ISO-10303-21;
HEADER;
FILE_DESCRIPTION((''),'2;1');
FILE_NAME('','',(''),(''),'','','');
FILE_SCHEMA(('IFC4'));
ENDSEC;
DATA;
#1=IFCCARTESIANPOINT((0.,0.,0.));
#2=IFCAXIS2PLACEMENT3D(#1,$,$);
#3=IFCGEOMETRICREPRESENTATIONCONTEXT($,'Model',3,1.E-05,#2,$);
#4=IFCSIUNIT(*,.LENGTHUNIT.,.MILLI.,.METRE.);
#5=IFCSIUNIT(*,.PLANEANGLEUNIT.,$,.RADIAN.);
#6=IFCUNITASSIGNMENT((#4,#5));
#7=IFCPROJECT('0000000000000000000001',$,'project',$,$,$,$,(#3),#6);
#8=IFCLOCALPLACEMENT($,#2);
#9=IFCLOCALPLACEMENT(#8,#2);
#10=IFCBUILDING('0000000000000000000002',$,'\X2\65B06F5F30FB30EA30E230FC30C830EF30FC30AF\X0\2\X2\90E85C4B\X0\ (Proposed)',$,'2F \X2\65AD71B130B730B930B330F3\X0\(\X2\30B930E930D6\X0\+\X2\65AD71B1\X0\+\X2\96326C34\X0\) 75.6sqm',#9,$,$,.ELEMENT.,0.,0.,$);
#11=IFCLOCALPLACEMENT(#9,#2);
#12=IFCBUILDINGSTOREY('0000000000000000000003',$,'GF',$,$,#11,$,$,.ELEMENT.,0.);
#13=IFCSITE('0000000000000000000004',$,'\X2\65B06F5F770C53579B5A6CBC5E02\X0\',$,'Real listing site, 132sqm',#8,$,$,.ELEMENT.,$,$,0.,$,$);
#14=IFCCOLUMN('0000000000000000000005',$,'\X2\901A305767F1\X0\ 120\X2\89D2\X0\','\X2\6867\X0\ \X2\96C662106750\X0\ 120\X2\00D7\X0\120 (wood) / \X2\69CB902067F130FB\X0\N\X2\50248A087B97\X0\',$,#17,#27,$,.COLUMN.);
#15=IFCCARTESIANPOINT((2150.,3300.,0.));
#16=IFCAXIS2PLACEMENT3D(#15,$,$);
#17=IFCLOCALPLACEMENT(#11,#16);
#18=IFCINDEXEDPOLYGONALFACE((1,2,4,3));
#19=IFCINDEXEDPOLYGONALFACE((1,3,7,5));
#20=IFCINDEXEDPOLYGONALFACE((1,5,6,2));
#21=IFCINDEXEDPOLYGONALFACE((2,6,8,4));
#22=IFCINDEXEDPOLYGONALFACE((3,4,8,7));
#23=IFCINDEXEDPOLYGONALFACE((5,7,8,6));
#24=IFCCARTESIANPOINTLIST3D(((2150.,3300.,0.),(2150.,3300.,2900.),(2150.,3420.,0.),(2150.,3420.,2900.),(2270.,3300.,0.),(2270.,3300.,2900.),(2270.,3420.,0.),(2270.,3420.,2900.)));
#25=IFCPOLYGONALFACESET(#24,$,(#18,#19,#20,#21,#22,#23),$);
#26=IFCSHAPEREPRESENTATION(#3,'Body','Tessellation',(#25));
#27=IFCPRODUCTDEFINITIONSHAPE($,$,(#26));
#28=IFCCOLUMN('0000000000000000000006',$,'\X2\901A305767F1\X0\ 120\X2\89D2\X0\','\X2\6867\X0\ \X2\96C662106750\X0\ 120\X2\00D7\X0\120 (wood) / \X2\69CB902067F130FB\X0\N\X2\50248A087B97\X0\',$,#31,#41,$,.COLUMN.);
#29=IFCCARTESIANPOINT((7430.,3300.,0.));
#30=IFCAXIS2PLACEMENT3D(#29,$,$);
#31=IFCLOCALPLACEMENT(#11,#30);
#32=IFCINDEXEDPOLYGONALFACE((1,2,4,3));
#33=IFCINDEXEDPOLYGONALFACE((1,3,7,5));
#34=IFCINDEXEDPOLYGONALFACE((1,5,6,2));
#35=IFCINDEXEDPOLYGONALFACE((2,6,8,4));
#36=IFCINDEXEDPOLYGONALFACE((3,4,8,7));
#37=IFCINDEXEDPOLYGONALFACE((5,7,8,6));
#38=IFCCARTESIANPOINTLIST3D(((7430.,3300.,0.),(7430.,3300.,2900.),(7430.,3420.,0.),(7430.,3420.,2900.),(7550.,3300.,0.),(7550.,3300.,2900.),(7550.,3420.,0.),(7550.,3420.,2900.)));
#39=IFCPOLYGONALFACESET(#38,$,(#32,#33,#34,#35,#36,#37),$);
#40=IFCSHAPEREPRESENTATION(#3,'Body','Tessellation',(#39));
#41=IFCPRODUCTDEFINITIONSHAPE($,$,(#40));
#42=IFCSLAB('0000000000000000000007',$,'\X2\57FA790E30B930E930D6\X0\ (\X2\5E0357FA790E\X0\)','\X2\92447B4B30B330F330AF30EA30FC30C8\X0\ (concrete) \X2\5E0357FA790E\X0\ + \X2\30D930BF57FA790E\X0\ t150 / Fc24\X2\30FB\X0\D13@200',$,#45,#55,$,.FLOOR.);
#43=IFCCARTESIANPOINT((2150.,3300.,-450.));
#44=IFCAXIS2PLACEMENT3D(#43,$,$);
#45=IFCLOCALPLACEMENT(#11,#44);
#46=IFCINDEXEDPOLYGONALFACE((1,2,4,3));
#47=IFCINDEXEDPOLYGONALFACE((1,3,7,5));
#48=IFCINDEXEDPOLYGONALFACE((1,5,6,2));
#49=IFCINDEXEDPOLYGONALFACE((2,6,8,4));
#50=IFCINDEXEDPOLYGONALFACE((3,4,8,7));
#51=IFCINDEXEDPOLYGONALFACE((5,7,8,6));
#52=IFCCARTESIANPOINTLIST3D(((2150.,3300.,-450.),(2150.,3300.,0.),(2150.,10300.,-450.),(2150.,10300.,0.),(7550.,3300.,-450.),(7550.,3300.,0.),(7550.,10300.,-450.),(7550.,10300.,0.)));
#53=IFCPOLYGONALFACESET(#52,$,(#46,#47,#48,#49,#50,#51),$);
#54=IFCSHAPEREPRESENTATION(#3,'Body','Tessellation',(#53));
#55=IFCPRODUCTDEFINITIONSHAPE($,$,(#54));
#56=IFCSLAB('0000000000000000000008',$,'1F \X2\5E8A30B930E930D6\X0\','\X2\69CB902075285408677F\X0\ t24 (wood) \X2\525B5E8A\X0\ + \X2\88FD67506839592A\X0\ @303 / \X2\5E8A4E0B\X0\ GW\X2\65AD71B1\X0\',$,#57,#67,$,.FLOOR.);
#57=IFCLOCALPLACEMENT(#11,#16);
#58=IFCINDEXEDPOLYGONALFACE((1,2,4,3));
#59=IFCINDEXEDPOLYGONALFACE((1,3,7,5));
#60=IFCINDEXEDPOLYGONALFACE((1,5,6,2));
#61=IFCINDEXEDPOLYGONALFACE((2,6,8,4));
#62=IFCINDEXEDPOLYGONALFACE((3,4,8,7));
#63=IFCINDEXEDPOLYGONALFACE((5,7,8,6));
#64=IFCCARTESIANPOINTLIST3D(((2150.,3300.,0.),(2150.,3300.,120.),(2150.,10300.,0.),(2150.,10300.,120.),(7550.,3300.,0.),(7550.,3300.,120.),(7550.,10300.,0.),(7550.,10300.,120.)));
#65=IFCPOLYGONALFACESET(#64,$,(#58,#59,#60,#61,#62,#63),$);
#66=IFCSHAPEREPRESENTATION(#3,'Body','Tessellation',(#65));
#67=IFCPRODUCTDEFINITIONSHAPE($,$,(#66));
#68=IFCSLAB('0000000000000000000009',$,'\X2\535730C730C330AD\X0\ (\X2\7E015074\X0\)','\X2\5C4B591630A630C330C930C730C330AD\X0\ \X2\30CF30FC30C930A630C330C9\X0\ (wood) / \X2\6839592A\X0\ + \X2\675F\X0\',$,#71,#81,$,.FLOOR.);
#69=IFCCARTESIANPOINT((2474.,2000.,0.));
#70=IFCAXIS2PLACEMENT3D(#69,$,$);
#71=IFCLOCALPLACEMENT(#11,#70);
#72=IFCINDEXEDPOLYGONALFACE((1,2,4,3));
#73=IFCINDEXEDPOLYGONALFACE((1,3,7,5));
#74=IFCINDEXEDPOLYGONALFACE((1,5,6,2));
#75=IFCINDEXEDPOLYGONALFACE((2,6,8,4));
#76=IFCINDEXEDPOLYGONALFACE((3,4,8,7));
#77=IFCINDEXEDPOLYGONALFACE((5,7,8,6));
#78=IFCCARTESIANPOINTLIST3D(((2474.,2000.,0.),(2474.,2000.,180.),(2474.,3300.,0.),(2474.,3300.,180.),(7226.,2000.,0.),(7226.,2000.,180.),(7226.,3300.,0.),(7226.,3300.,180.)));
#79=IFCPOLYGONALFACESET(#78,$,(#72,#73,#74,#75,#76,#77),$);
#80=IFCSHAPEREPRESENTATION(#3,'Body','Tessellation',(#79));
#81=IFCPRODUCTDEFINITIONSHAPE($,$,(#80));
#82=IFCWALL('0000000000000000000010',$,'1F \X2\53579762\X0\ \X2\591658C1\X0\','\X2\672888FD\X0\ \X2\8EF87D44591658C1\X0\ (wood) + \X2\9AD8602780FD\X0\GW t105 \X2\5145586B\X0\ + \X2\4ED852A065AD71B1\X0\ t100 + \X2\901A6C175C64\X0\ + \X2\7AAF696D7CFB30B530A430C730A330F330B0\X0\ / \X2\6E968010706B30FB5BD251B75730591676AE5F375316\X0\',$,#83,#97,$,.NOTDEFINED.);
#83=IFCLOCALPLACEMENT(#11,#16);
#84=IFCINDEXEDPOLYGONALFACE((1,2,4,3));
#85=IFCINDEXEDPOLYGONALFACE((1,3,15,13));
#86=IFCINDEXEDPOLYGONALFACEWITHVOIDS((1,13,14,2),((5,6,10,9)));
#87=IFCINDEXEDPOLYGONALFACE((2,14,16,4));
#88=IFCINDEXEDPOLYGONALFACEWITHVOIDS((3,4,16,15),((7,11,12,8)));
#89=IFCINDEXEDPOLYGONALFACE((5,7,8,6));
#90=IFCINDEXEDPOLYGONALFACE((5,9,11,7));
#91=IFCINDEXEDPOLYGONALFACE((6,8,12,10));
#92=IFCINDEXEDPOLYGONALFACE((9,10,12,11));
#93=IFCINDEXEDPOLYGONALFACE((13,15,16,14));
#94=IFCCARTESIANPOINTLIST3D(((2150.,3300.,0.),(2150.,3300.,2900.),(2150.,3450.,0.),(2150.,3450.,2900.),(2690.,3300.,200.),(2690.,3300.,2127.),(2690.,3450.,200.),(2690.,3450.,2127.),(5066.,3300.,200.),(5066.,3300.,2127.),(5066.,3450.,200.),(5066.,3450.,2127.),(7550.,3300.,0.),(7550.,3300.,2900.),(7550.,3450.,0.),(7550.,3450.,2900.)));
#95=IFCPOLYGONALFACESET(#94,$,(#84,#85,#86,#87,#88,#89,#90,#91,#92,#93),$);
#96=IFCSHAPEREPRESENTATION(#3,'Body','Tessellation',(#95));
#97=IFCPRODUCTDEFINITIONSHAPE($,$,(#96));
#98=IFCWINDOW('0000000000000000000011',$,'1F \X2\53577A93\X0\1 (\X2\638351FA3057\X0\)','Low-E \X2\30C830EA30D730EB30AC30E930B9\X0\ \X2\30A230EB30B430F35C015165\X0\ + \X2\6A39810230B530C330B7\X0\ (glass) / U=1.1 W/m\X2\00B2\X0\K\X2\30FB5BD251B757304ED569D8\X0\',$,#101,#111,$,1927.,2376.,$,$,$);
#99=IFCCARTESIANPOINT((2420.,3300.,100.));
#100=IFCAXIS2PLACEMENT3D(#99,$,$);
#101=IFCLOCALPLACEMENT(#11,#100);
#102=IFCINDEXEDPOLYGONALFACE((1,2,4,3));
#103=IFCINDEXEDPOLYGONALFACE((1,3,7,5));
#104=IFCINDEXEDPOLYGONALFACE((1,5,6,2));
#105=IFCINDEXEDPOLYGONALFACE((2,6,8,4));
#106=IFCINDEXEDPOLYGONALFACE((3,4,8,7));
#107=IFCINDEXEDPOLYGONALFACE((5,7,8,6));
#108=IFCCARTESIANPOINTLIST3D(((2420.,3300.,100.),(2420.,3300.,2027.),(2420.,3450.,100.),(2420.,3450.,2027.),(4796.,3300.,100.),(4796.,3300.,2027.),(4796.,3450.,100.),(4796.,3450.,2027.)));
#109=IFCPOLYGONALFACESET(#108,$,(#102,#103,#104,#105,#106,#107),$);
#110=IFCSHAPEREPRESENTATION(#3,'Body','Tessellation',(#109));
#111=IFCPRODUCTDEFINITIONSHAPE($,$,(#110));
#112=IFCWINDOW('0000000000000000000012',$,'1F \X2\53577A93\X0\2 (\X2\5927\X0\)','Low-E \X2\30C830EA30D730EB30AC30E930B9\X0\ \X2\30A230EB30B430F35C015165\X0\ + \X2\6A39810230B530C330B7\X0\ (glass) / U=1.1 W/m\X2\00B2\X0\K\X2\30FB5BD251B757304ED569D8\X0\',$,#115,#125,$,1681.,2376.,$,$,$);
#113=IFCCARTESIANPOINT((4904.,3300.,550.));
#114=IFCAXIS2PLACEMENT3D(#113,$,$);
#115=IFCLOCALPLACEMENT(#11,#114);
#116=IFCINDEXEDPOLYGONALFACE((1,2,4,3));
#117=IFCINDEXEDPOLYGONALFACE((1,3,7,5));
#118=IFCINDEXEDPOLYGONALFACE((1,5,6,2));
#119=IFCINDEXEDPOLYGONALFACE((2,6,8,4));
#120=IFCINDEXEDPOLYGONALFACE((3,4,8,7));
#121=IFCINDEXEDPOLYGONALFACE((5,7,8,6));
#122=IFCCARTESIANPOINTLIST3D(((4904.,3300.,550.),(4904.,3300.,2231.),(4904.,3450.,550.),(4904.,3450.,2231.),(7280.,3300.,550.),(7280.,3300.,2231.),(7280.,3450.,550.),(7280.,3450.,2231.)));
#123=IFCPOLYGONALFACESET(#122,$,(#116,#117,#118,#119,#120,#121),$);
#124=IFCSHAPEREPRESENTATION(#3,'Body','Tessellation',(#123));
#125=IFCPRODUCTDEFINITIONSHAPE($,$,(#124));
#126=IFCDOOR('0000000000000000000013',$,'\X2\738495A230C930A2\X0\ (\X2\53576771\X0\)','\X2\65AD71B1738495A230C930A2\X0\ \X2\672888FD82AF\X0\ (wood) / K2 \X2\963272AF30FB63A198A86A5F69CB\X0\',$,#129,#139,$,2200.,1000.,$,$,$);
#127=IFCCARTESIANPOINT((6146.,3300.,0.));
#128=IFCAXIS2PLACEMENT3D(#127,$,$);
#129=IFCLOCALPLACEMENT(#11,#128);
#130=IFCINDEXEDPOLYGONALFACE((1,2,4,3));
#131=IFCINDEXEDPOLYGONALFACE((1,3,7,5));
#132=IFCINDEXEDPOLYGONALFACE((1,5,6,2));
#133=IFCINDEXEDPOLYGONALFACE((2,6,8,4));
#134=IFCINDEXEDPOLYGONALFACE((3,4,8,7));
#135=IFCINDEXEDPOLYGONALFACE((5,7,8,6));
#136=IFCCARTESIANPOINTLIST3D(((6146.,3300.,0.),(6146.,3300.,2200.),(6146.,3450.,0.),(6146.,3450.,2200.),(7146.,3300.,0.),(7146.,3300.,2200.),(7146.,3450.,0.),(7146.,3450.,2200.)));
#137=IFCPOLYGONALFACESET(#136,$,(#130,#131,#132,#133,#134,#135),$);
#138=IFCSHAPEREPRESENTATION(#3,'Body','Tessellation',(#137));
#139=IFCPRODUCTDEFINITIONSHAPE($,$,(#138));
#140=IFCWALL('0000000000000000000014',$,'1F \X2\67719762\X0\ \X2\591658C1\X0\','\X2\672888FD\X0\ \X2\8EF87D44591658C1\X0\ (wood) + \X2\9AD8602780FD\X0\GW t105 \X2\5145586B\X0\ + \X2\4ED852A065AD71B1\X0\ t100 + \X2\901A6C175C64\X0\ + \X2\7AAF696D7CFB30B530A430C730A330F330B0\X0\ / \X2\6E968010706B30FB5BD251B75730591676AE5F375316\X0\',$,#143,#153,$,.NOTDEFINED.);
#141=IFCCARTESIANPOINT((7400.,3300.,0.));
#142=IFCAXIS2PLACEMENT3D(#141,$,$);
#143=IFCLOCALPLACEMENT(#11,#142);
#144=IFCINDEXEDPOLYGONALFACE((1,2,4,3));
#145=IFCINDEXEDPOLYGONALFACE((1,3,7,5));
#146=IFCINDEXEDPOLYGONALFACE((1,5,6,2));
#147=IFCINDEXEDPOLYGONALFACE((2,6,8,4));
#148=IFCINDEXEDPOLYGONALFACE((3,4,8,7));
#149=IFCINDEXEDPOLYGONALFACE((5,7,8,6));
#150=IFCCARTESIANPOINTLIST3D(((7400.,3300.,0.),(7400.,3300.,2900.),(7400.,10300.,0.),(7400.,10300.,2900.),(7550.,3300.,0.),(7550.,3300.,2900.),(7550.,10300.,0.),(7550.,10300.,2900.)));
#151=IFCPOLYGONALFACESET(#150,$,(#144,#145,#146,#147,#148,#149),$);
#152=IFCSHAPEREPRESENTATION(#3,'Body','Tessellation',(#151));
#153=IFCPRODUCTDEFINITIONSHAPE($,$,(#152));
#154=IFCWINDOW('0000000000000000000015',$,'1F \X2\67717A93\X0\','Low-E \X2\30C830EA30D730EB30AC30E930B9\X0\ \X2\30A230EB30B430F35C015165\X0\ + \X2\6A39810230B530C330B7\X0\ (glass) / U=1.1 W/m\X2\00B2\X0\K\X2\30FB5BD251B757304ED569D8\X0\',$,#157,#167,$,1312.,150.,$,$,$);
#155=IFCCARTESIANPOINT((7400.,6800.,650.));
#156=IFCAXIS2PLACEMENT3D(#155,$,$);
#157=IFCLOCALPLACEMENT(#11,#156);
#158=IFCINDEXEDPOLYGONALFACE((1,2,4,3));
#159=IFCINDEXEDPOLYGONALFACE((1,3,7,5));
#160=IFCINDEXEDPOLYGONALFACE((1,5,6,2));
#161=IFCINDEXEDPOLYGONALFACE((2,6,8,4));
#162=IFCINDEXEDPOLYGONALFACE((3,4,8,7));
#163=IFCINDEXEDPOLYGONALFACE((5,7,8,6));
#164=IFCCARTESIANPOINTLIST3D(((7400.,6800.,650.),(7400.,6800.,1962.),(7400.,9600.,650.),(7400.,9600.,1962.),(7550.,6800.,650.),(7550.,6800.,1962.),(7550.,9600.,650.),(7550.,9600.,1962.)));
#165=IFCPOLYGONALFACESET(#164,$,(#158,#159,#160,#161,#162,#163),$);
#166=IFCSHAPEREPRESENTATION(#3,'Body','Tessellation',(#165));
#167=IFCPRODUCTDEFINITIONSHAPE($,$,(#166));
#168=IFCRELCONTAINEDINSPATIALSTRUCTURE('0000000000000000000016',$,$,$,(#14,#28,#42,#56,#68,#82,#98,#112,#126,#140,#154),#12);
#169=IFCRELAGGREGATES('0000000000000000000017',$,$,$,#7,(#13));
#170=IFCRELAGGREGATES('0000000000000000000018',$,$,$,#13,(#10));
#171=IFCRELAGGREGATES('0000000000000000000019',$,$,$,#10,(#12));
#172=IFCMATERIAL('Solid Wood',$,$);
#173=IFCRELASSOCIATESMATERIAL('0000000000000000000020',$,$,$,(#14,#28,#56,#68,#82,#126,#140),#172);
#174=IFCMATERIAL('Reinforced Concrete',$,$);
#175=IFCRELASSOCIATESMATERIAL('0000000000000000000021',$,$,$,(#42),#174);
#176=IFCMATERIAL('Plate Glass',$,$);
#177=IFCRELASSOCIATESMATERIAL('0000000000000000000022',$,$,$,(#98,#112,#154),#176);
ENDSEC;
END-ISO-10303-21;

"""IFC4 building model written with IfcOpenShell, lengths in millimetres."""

from ifc_helpers import new_model, si_unit, frame, frame_2d, origin, place, context, project, spatial, rectangle, extrude, material, element, fill, save


model = new_model("IFC4")

# Units and contexts
model_context = context("Model", 3, precision=1e-05, world=origin())
ifc_project = project(units=[si_unit("LENGTHUNIT", "METRE", prefix="MILLI"), si_unit("PLANEANGLEUNIT", "RADIAN")], contexts=[model_context])

# Site, building, storey
site_placement = place(None, origin())
site = spatial("IfcSite", under=ifc_project, at=site_placement, Name="新潟県南魚沼市", ObjectType="Real listing site, 132sqm", CompositionType="ELEMENT", RefElevation=0.0)
building_placement = place(site_placement, origin())
building = spatial("IfcBuilding", under=site, at=building_placement, Name="新潟・リモートワーク2部屋 (Proposed)", ObjectType="2F 断熱シスコン(スラブ+断熱+防水) 75.6sqm", CompositionType="ELEMENT", ElevationOfRefHeight=0.0, ElevationOfTerrain=0.0)
storey_placement = place(building_placement, origin())
storey = spatial("IfcBuildingStorey", under=building, at=storey_placement, Name="GF", CompositionType="ELEMENT", Elevation=0.0)

# Columns
ifc_material_1 = material(Name="Solid Wood")
column_1_placement = place(storey_placement, frame((2150.0, 3300.0, 0.0)))
element("IfcColumn", 1, at=column_1_placement, inside=storey, material=ifc_material_1, Name="通し柱 120角", Description="桧 集成材 120×120 (wood) / 構造柱・N値計算", PredefinedType="COLUMN", context=model_context, shape_type="SweptSolid", body=[
    extrude(rectangle(XDim=120.0, YDim=120.0, at=frame_2d((60.0, 60.0))), frame((2150.0, 3300.0, 0.0)), (0.0, 0.0, 1.0), 2900.0),
])
column_2_placement = place(storey_placement, frame((7430.0, 3300.0, 0.0)))
element("IfcColumn", 2, at=column_2_placement, inside=storey, material=ifc_material_1, Name="通し柱 120角", Description="桧 集成材 120×120 (wood) / 構造柱・N値計算", PredefinedType="COLUMN", context=model_context, shape_type="SweptSolid", body=[
    extrude(rectangle(XDim=120.0, YDim=120.0, at=frame_2d((60.0, 60.0))), frame((7430.0, 3300.0, 0.0)), (0.0, 0.0, 1.0), 2900.0),
])

# Slabs
ifc_material_2 = material(Name="Reinforced Concrete")
slab_1_placement = place(storey_placement, frame((2150.0, 3300.0, -450.0)))
element("IfcSlab", 3, at=slab_1_placement, inside=storey, material=ifc_material_2, Name="基礎スラブ (布基礎)", Description="鉄筋コンクリート (concrete) 布基礎 + ベタ基礎 t150 / Fc24・D13@200", PredefinedType="FLOOR", context=model_context, shape_type="SweptSolid", body=[
    extrude(rectangle(XDim=5400.0, YDim=7000.0, at=frame_2d((2700.0, 3500.0))), frame((2150.0, 3300.0, -450.0)), (0.0, 0.0, 1.0), 450.0),
])
slab_2_placement = place(storey_placement, frame((2150.0, 3300.0, 0.0)))
element("IfcSlab", 4, at=slab_2_placement, inside=storey, material=ifc_material_1, Name="1F 床スラブ", Description="構造用合板 t24 (wood) 剛床 + 製材根太 @303 / 床下 GW断熱", PredefinedType="FLOOR", context=model_context, shape_type="SweptSolid", body=[
    extrude(rectangle(XDim=5400.0, YDim=7000.0, at=frame_2d((2700.0, 3500.0))), frame((2150.0, 3300.0, 0.0)), (0.0, 0.0, 1.0), 120.0),
])
slab_3_placement = place(storey_placement, frame((2474.0, 2000.0, 0.0)))
element("IfcSlab", 5, at=slab_3_placement, inside=storey, material=ifc_material_1, Name="南デッキ (縁側)", Description="屋外ウッドデッキ ハードウッド (wood) / 根太 + 束", PredefinedType="FLOOR", context=model_context, shape_type="SweptSolid", body=[
    extrude(rectangle(XDim=4752.0, YDim=1300.0, at=frame_2d((2376.0, 650.0))), frame((2474.0, 2000.0, 0.0)), (0.0, 0.0, 1.0), 180.0),
])

# Wall, openings, windows, door
wall_1_placement = place(storey_placement, frame((2150.0, 3300.0, 0.0)))
wall_1 = element("IfcWall", 6, at=wall_1_placement, inside=storey, material=ifc_material_1, Name="1F 南面 外壁", Description="木製 軸組外壁 (wood) + 高性能GW t105 充填 + 付加断熱 t100 + 通気層 + 窯業系サイディング / 準耐火・寒冷地外皮強化", PredefinedType="NOTDEFINED", context=model_context, shape_type="SweptSolid", body=[
    extrude(rectangle(XDim=5400.0, YDim=150.0, at=frame_2d((2700.0, 75.0))), frame((2150.0, 3300.0, 0.0)), (0.0, 0.0, 1.0), 2900.0),
])
opening_1_placement = place(storey_placement, frame((2420.0, 3300.0, 100.0)))
opening_1 = element("IfcOpeningElement", 7, at=opening_1_placement, cuts=wall_1, PredefinedType="NOTDEFINED", context=model_context, shape_type="SweptSolid", body=[
    extrude(rectangle(XDim=2376.0, YDim=150.0, at=frame_2d((1188.0, 75.0))), frame((2420.0, 3300.0, 100.0)), (0.0, 0.0, 1.0), 1927.0),
])
opening_2_placement = place(storey_placement, frame((4904.0, 3300.0, 550.0)))
opening_2 = element("IfcOpeningElement", 8, at=opening_2_placement, cuts=wall_1, PredefinedType="NOTDEFINED", context=model_context, shape_type="SweptSolid", body=[
    extrude(rectangle(XDim=2376.0, YDim=150.0, at=frame_2d((1188.0, 75.0))), frame((4904.0, 3300.0, 550.0)), (0.0, 0.0, 1.0), 1681.0),
])
opening_3_placement = place(storey_placement, frame((6146.0, 3300.0, 0.0)))
opening_3 = element("IfcOpeningElement", 9, at=opening_3_placement, cuts=wall_1, PredefinedType="NOTDEFINED", context=model_context, shape_type="SweptSolid", body=[
    extrude(rectangle(XDim=1000.0, YDim=150.0, at=frame_2d((500.0, 75.0))), frame((6146.0, 3300.0, 0.0)), (0.0, 0.0, 1.0), 2200.0),
])
ifc_material_3 = material(Name="Plate Glass")
window_1_placement = place(storey_placement, frame((2420.0, 3300.0, 100.0)))
window_1 = element("IfcWindow", 10, at=window_1_placement, inside=storey, material=ifc_material_3, Name="1F 南窓1 (掃出し)", Description="Low-E トリプルガラス アルゴン封入 + 樹脂サッシ (glass) / U=1.1 W/m²K・寒冷地仕様", OverallHeight=1927.0, OverallWidth=2376.0, context=model_context, shape_type="SweptSolid", body=[
    extrude(rectangle(XDim=2376.0, YDim=150.0, at=frame_2d((1188.0, 75.0))), frame((2420.0, 3300.0, 100.0)), (0.0, 0.0, 1.0), 1927.0),
])
fill(opening_1, window_1)
window_2_placement = place(storey_placement, frame((4904.0, 3300.0, 550.0)))
window_2 = element("IfcWindow", 11, at=window_2_placement, inside=storey, material=ifc_material_3, Name="1F 南窓2 (大)", Description="Low-E トリプルガラス アルゴン封入 + 樹脂サッシ (glass) / U=1.1 W/m²K・寒冷地仕様", OverallHeight=1681.0, OverallWidth=2376.0, context=model_context, shape_type="SweptSolid", body=[
    extrude(rectangle(XDim=2376.0, YDim=150.0, at=frame_2d((1188.0, 75.0))), frame((4904.0, 3300.0, 550.0)), (0.0, 0.0, 1.0), 1681.0),
])
fill(opening_2, window_2)
door_placement = place(storey_placement, frame((6146.0, 3300.0, 0.0)))
door = element("IfcDoor", 12, at=door_placement, inside=storey, material=ifc_material_1, Name="玄関ドア (南東)", Description="断熱玄関ドア 木製芯 (wood) / K2 防犯・採風機構", OverallHeight=2200.0, OverallWidth=1000.0, context=model_context, shape_type="SweptSolid", body=[
    extrude(rectangle(XDim=1000.0, YDim=150.0, at=frame_2d((500.0, 75.0))), frame((6146.0, 3300.0, 0.0)), (0.0, 0.0, 1.0), 2200.0),
])
fill(opening_3, door)

# Wall, opening, window
wall_2_placement = place(storey_placement, frame((7400.0, 3300.0, 0.0)))
wall_2 = element("IfcWall", 13, at=wall_2_placement, inside=storey, material=ifc_material_1, Name="1F 東面 外壁", Description="木製 軸組外壁 (wood) + 高性能GW t105 充填 + 付加断熱 t100 + 通気層 + 窯業系サイディング / 準耐火・寒冷地外皮強化", PredefinedType="NOTDEFINED", context=model_context, shape_type="SweptSolid", body=[
    extrude(rectangle(XDim=150.0, YDim=7000.0, at=frame_2d((75.0, 3500.0))), frame((7400.0, 3300.0, 0.0)), (0.0, 0.0, 1.0), 2900.0),
])
opening_4_placement = place(storey_placement, frame((7400.0, 6800.0, 650.0)))
opening_4 = element("IfcOpeningElement", 14, at=opening_4_placement, cuts=wall_2, PredefinedType="NOTDEFINED", context=model_context, shape_type="SweptSolid", body=[
    extrude(rectangle(XDim=150.0, YDim=2800.0, at=frame_2d((75.0, 1400.0))), frame((7400.0, 6800.0, 650.0)), (0.0, 0.0, 1.0), 1312.0),
])
window_3_placement = place(storey_placement, frame((7400.0, 6800.0, 650.0)))
window_3 = element("IfcWindow", 15, at=window_3_placement, inside=storey, material=ifc_material_3, Name="1F 東窓", Description="Low-E トリプルガラス アルゴン封入 + 樹脂サッシ (glass) / U=1.1 W/m²K・寒冷地仕様", OverallHeight=1312.0, OverallWidth=150.0, context=model_context, shape_type="SweptSolid", body=[
    extrude(rectangle(XDim=150.0, YDim=2800.0, at=frame_2d((75.0, 1400.0))), frame((7400.0, 6800.0, 650.0)), (0.0, 0.0, 1.0), 1312.0),
])
fill(opening_4, window_3)

save(model, "model.ifc")
